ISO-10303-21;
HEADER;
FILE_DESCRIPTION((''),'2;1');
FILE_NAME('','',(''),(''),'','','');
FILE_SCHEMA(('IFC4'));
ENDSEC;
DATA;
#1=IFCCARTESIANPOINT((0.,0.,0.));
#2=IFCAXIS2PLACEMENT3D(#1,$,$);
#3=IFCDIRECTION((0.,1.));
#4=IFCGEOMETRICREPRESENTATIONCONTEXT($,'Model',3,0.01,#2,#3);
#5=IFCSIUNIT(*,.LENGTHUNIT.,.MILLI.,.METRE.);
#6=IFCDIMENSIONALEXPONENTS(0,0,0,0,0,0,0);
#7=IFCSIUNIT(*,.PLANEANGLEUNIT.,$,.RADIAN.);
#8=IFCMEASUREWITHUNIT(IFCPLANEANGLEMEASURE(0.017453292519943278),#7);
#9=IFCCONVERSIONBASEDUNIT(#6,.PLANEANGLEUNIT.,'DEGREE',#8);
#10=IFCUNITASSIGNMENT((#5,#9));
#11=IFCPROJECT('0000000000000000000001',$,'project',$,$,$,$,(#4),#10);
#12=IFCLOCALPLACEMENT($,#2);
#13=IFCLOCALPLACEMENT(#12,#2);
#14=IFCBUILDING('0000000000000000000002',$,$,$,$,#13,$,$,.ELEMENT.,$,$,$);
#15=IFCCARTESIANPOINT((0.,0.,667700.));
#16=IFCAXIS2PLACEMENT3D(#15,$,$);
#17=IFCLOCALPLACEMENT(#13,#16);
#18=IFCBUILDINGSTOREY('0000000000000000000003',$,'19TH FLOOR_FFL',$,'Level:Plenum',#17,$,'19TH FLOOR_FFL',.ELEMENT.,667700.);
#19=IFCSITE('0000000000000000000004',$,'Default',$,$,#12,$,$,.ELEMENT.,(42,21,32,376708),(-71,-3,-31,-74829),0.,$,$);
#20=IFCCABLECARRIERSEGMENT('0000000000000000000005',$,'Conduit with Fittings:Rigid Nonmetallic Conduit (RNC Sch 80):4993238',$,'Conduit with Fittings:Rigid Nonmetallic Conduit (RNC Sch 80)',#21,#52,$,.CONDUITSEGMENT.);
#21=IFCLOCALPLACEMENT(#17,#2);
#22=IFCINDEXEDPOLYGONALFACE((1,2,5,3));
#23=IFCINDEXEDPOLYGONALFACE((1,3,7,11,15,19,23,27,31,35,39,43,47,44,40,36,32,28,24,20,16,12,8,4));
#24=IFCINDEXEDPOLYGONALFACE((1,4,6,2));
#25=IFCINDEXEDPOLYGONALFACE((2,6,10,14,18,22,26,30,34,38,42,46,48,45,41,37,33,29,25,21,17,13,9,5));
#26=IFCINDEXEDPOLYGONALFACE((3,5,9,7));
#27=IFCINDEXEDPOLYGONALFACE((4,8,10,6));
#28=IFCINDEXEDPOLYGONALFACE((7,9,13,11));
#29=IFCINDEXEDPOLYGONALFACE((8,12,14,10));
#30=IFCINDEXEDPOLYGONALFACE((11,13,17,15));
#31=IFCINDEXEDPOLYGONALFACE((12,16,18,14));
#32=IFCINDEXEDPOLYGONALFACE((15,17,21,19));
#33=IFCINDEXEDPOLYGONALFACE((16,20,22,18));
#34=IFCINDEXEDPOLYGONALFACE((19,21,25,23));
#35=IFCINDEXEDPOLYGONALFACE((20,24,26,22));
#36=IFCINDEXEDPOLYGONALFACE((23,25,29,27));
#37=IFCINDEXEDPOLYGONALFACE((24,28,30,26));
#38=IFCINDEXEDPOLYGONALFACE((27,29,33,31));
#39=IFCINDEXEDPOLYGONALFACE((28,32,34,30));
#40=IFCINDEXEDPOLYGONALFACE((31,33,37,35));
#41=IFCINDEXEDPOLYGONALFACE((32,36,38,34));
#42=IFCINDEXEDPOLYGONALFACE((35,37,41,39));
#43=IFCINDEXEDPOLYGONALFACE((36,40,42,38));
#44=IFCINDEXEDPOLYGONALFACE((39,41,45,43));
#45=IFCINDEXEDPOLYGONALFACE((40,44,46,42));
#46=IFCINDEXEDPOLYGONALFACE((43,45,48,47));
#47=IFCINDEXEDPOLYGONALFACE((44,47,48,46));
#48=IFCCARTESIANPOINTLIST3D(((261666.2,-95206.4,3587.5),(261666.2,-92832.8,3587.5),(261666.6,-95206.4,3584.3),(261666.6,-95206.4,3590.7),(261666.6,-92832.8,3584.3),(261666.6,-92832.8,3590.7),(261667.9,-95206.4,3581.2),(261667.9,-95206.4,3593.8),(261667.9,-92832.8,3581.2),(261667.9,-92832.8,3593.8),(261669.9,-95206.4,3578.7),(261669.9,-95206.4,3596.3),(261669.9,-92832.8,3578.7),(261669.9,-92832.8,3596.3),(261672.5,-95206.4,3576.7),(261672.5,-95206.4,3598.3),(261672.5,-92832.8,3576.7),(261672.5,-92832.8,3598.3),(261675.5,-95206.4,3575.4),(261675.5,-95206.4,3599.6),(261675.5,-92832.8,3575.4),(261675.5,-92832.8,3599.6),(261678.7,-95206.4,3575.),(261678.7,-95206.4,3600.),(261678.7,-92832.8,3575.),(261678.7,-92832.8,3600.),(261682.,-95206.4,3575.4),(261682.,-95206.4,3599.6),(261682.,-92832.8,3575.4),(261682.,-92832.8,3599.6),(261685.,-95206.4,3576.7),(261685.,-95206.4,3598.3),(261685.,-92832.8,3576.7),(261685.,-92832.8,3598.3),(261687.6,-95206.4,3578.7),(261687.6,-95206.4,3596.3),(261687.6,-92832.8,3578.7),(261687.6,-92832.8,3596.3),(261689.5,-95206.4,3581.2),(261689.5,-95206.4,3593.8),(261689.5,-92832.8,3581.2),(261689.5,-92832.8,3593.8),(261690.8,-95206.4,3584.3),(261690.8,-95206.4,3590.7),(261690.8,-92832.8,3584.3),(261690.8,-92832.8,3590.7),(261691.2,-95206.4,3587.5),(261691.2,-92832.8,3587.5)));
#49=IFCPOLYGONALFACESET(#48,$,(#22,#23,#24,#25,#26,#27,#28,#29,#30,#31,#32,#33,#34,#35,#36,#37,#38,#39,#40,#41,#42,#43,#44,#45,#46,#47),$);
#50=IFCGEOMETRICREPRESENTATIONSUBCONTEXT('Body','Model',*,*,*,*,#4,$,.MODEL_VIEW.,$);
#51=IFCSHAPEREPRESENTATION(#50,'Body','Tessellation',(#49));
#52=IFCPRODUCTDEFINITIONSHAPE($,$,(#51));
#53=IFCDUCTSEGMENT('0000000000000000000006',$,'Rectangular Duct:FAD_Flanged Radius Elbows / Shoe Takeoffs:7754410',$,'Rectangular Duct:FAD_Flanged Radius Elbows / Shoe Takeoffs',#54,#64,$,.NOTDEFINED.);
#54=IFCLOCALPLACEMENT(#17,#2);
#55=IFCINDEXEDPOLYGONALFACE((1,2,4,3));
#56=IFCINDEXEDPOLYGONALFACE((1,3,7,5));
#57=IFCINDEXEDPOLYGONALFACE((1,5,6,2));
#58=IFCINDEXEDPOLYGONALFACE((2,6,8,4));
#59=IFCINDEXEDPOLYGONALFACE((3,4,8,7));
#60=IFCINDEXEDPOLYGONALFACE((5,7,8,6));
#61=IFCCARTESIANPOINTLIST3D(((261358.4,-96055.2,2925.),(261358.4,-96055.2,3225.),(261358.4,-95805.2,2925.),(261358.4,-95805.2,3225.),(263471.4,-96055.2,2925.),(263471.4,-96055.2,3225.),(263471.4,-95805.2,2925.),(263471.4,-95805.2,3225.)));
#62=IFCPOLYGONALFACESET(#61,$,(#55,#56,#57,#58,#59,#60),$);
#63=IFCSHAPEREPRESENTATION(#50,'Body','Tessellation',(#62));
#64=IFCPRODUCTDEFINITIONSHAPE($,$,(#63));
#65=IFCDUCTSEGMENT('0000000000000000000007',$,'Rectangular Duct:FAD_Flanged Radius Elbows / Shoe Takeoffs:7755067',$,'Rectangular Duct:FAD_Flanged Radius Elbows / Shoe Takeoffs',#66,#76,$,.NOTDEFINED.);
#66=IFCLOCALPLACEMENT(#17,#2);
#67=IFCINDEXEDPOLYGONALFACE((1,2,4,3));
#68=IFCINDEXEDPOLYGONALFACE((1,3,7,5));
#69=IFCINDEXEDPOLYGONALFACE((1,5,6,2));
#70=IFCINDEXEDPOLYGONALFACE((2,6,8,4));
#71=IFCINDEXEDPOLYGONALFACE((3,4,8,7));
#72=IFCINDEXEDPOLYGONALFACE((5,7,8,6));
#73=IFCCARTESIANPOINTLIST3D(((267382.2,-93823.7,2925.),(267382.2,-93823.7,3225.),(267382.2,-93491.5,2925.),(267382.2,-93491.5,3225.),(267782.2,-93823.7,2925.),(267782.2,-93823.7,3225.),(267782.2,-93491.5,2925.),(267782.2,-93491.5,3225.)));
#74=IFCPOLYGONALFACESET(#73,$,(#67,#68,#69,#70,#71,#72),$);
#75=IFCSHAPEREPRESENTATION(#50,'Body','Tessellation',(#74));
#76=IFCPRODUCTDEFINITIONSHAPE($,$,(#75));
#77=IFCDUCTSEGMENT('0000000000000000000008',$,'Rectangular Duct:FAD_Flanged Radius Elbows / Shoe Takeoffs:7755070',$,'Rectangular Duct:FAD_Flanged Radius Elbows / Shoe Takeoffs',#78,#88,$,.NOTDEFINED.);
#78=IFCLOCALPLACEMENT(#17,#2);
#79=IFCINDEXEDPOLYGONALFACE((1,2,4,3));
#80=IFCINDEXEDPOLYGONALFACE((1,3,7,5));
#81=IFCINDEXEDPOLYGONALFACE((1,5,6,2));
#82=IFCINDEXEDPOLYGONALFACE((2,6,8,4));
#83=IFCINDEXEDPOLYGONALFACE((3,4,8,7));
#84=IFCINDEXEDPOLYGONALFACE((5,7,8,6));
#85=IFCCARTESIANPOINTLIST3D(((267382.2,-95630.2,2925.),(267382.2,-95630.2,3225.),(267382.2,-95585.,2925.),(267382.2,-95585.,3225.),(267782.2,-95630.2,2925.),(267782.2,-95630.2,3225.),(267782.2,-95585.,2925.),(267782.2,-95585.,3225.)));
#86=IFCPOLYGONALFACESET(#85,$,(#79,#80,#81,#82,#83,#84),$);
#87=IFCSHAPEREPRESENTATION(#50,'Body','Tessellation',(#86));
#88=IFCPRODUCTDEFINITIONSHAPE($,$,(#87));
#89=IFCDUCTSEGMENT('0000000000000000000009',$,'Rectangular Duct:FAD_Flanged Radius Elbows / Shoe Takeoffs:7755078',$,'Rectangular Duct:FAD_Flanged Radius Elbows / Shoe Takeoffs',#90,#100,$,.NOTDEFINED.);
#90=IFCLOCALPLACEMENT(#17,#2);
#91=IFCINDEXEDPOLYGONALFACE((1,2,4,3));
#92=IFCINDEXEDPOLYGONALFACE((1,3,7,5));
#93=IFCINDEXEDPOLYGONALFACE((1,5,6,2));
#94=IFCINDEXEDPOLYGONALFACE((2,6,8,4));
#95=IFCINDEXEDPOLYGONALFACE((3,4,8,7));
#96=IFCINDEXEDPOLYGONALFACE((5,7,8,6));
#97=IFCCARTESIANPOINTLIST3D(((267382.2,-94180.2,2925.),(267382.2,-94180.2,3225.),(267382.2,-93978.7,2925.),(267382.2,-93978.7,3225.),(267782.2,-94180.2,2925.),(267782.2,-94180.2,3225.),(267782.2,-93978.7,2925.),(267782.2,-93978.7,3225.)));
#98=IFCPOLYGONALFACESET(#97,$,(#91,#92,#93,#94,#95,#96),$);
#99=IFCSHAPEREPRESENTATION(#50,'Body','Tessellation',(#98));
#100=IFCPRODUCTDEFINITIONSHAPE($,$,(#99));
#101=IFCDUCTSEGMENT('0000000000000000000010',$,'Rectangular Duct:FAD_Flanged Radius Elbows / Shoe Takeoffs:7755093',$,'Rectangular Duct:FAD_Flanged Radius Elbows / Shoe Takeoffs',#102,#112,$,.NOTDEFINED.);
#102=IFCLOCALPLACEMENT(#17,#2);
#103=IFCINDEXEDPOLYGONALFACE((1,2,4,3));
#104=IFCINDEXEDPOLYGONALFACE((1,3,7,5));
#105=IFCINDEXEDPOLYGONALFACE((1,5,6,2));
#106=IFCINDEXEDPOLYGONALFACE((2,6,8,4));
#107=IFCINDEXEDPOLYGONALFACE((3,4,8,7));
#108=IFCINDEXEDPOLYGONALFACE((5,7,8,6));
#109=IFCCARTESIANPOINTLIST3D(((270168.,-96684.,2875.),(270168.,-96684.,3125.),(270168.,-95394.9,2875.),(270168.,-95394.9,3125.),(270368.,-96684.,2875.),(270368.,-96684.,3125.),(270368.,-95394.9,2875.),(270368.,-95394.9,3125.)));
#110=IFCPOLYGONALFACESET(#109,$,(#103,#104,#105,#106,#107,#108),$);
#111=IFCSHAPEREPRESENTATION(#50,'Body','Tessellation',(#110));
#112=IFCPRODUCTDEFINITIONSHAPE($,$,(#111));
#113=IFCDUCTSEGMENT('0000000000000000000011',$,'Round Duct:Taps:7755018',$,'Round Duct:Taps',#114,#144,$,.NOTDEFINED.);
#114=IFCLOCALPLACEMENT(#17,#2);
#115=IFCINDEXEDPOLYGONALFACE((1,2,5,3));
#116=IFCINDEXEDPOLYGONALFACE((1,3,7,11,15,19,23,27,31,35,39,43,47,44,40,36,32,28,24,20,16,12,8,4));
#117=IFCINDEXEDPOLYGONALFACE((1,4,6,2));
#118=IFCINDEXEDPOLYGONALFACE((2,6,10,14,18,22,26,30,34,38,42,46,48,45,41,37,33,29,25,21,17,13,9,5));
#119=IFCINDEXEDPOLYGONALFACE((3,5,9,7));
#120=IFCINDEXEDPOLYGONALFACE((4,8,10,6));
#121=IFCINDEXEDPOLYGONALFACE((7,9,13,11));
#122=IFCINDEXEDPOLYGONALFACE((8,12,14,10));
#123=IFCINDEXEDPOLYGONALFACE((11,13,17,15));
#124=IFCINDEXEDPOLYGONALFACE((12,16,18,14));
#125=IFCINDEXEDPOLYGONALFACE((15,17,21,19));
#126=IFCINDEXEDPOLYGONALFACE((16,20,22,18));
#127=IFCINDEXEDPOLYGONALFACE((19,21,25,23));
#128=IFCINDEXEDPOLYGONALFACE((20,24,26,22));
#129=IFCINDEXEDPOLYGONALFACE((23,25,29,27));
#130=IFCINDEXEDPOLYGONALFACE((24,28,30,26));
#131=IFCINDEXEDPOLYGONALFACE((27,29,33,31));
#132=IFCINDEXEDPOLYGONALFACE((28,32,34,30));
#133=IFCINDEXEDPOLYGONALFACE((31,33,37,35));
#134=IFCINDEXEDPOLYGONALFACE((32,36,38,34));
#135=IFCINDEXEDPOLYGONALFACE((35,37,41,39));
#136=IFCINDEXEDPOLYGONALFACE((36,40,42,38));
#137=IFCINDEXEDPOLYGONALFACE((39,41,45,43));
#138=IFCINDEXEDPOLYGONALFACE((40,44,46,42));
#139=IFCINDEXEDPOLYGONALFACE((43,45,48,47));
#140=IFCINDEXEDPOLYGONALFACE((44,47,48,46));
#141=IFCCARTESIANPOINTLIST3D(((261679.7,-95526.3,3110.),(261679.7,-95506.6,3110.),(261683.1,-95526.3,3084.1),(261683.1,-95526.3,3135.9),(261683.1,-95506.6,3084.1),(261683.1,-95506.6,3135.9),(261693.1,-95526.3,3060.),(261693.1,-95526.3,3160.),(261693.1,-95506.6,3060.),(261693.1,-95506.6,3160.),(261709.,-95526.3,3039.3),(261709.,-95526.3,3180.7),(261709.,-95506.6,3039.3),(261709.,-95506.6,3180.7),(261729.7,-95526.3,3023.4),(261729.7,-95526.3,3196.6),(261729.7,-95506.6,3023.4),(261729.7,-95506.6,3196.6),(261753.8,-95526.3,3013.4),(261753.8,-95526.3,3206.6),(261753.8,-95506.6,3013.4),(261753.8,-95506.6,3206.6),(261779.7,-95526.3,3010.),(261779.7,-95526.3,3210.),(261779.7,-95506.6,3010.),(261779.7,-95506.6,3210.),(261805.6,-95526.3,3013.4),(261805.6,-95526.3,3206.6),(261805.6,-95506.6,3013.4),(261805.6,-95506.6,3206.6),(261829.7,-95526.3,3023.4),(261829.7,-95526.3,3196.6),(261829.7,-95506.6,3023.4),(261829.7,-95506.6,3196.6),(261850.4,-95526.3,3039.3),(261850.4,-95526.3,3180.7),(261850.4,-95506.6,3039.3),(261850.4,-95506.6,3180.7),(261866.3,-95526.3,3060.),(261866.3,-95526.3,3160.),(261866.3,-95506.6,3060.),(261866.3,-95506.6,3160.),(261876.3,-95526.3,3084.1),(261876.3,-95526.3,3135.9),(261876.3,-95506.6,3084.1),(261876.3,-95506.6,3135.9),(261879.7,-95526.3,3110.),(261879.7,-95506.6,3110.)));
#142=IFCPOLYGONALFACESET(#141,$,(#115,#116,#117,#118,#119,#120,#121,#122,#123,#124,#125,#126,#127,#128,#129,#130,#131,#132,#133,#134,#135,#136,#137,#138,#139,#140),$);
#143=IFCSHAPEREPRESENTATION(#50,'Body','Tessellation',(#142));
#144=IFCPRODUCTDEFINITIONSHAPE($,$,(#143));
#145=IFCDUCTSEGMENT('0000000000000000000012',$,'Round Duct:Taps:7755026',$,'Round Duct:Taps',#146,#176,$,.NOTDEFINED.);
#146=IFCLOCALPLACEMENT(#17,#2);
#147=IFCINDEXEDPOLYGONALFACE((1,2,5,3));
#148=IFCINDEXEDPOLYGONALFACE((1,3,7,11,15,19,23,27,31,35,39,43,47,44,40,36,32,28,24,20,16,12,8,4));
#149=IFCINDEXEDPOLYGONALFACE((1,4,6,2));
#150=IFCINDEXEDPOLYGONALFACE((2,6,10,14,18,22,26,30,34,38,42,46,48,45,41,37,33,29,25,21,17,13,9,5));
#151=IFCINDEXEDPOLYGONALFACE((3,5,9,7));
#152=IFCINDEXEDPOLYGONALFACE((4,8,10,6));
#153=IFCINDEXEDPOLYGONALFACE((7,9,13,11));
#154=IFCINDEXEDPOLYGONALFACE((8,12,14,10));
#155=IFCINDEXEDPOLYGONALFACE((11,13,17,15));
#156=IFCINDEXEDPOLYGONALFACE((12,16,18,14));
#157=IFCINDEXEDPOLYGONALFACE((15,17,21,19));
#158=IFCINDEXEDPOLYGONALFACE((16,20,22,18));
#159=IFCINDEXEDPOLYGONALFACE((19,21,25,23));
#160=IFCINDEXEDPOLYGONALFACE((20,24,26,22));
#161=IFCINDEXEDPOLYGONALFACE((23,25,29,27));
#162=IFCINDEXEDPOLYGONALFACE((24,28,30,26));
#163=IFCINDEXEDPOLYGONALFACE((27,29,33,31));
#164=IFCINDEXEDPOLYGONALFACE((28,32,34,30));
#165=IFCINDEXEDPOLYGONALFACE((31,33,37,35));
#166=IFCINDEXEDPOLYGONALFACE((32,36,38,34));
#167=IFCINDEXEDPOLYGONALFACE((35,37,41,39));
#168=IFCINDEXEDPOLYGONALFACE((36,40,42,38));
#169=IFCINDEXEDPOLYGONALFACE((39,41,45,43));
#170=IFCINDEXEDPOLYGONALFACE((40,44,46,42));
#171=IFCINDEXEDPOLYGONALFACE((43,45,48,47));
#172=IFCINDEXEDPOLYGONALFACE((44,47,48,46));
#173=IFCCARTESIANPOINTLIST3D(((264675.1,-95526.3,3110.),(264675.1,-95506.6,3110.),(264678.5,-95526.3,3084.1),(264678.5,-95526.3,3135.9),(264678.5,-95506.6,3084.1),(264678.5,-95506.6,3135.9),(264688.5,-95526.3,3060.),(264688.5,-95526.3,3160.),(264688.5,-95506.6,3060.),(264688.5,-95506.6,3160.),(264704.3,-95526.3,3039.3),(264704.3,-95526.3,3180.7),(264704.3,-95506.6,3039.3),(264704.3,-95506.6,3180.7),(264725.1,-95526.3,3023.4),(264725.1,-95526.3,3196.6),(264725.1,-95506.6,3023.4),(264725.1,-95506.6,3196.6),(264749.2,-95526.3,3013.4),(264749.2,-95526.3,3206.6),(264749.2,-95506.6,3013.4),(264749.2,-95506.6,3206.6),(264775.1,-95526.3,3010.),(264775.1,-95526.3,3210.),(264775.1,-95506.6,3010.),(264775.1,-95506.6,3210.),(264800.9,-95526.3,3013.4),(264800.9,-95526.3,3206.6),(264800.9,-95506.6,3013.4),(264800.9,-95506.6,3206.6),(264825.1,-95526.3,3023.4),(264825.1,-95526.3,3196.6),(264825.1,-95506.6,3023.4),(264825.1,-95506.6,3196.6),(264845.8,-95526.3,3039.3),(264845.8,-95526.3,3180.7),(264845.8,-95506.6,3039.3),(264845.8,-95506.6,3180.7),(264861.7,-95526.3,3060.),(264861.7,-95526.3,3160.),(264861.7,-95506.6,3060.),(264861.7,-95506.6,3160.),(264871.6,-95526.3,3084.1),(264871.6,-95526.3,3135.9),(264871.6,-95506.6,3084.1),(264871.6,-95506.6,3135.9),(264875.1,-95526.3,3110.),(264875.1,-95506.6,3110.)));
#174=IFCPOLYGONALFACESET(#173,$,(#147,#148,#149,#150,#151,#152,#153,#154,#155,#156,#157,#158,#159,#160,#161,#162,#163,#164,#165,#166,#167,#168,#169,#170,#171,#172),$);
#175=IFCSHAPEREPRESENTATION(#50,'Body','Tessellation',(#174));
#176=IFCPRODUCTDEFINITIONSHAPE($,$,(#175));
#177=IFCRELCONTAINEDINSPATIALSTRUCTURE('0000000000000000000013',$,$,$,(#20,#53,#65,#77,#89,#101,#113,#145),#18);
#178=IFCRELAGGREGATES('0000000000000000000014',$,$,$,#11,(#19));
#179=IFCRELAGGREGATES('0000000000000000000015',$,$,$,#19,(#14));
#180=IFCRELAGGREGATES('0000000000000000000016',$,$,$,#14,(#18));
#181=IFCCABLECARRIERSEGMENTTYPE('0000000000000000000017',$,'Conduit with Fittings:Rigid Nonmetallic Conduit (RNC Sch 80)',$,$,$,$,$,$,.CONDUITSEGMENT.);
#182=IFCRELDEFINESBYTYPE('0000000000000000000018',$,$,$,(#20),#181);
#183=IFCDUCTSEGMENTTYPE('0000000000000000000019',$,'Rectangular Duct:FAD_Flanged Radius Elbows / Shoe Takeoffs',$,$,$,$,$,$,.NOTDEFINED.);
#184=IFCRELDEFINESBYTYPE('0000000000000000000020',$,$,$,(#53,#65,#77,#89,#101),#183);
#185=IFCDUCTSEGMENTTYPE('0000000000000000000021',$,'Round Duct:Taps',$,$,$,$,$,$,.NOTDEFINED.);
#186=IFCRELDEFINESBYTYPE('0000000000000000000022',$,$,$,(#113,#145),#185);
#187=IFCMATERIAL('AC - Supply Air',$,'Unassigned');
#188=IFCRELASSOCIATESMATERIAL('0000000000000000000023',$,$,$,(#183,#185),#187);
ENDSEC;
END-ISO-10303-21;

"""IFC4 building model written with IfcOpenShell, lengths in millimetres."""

from ifc_helpers import new_model, entity, si_unit, converted_unit, direction, frame, origin, place, context, subcontext, project, spatial, arc, indexed_curve, outline, extrude, material, type_object, element, save


model = new_model("IFC4")

# Units and contexts
model_context = context("Model", 3, precision=0.01, world=origin(), true_north=direction((0.0, 1.0)))
body_context = subcontext(model_context, "Body", "Model", "MODEL_VIEW")
ifc_project = project(units=[si_unit("LENGTHUNIT", "METRE", prefix="MILLI"), converted_unit("PLANEANGLEUNIT", "DEGREE", entity("IfcPlaneAngleMeasure", 0.017453292519943278), si_unit("PLANEANGLEUNIT", "RADIAN"), dimensions=[0, 0, 0, 0, 0, 0, 0])], contexts=[model_context])

# Site, building, storey
site_placement = place(None, origin())
site = spatial("IfcSite", under=ifc_project, at=site_placement, Name="Default", CompositionType="ELEMENT", RefLatitude=(42, 21, 32, 376708), RefLongitude=(-71, -3, -31, -74829), RefElevation=0.0)
building_placement = place(site_placement, origin())
building = spatial("IfcBuilding", under=site, at=building_placement, CompositionType="ELEMENT")
storey_placement = place(building_placement, frame((0.0, 0.0, 667700.0)))
storey = spatial("IfcBuildingStorey", under=building, at=storey_placement, Name="19TH FLOOR_FFL", ObjectType="Level:Plenum", LongName="19TH FLOOR_FFL", CompositionType="ELEMENT", Elevation=667700.0)

# Cable carrier segment
cable_carrier_segment_type_1 = type_object("IfcCableCarrierSegmentType", Name="Conduit with Fittings:Rigid Nonmetallic Conduit (RNC Sch 80)", PredefinedType="CONDUITSEGMENT")
cable_carrier_segment_1_placement = place(storey_placement, origin())
element("IfcCableCarrierSegment", 1, at=cable_carrier_segment_1_placement, inside=storey, type_object=cable_carrier_segment_type_1, Name="Conduit with Fittings:Rigid Nonmetallic Conduit (RNC Sch 80):4993238", ObjectType="Conduit with Fittings:Rigid Nonmetallic Conduit (RNC Sch 80)", PredefinedType="CONDUITSEGMENT", context=body_context, shape_type="SweptSolid", body=[
    extrude(outline(indexed_curve([(12.5, 0.0), (8.8, 8.8), (0.0, 12.5), (-8.8, 8.8), (-12.5, 0.0), (-8.8, -8.8), (0.0, -12.5), (8.8, -8.8)], segments=[arc(1, 2, 3), arc(3, 4, 5), arc(5, 6, 7), arc(7, 8, 1)], self_intersect=False)), frame((261678.7, -95206.4, 3587.5), z_axis=(0.0, 1.0, 0.0), x_axis=(1.0, 0.0, 0.0)), (0.0, 0.0, 1.0), 2373.6),
])

# Duct segments
ifc_material_1 = material(Name="AC - Supply Air", Category="Unassigned")
duct_segment_type_1 = type_object("IfcDuctSegmentType", Name="Rectangular Duct:FAD_Flanged Radius Elbows / Shoe Takeoffs", PredefinedType="NOTDEFINED", material=ifc_material_1)
duct_segment_1_placement = place(storey_placement, origin())
element("IfcDuctSegment", 2, at=duct_segment_1_placement, inside=storey, type_object=duct_segment_type_1, Name="Rectangular Duct:FAD_Flanged Radius Elbows / Shoe Takeoffs:7754410", ObjectType="Rectangular Duct:FAD_Flanged Radius Elbows / Shoe Takeoffs", PredefinedType="NOTDEFINED", context=body_context, shape_type="SweptSolid", body=[
    extrude(outline(indexed_curve([(-1056.5, -125.0), (1056.5, -125.0), (1056.5, 125.0), (-1056.5, 125.0), (-1056.5, -125.0)], self_intersect=False)), frame((262414.9, -95930.2, 2925.0), z_axis=(0.0, 0.0, 1.0), x_axis=(-1.0, 0.0, 0.0)), (0.0, 0.0, 1.0), 300.0),
])
duct_segment_2_placement = place(storey_placement, origin())
element("IfcDuctSegment", 3, at=duct_segment_2_placement, inside=storey, type_object=duct_segment_type_1, Name="Rectangular Duct:FAD_Flanged Radius Elbows / Shoe Takeoffs:7755067", ObjectType="Rectangular Duct:FAD_Flanged Radius Elbows / Shoe Takeoffs", PredefinedType="NOTDEFINED", context=body_context, shape_type="SweptSolid", body=[
    extrude(outline(indexed_curve([(-166.1, -200.0), (166.1, -200.0), (166.1, 200.0), (-166.1, 200.0), (-166.1, -200.0)], self_intersect=False)), frame((267582.2, -93657.6, 2925.0), z_axis=(0.0, 0.0, 1.0), x_axis=(0.0, 1.0, 0.0)), (0.0, 0.0, 1.0), 300.0),
])
duct_segment_3_placement = place(storey_placement, origin())
element("IfcDuctSegment", 4, at=duct_segment_3_placement, inside=storey, type_object=duct_segment_type_1, Name="Rectangular Duct:FAD_Flanged Radius Elbows / Shoe Takeoffs:7755070", ObjectType="Rectangular Duct:FAD_Flanged Radius Elbows / Shoe Takeoffs", PredefinedType="NOTDEFINED", context=body_context, shape_type="SweptSolid", body=[
    extrude(outline(indexed_curve([(-22.6, -200.0), (22.6, -200.0), (22.6, 200.0), (-22.6, 200.0), (-22.6, -200.0)], self_intersect=False)), frame((267582.2, -95607.6, 2925.0), z_axis=(0.0, 0.0, 1.0), x_axis=(0.0, -1.0, 0.0)), (0.0, 0.0, 1.0), 300.0),
])
duct_segment_4_placement = place(storey_placement, origin())
element("IfcDuctSegment", 5, at=duct_segment_4_placement, inside=storey, type_object=duct_segment_type_1, Name="Rectangular Duct:FAD_Flanged Radius Elbows / Shoe Takeoffs:7755078", ObjectType="Rectangular Duct:FAD_Flanged Radius Elbows / Shoe Takeoffs", PredefinedType="NOTDEFINED", context=body_context, shape_type="SweptSolid", body=[
    extrude(outline(indexed_curve([(-100.7, -200.0), (100.7, -200.0), (100.7, 200.0), (-100.7, 200.0), (-100.7, -200.0)], self_intersect=False)), frame((267582.2, -94079.4, 2925.0), z_axis=(0.0, 0.0, 1.0), x_axis=(0.0, 1.0, 0.0)), (0.0, 0.0, 1.0), 300.0),
])
duct_segment_5_placement = place(storey_placement, origin())
element("IfcDuctSegment", 6, at=duct_segment_5_placement, inside=storey, type_object=duct_segment_type_1, Name="Rectangular Duct:FAD_Flanged Radius Elbows / Shoe Takeoffs:7755093", ObjectType="Rectangular Duct:FAD_Flanged Radius Elbows / Shoe Takeoffs", PredefinedType="NOTDEFINED", context=body_context, shape_type="SweptSolid", body=[
    extrude(outline(indexed_curve([(-644.5, -100.0), (644.5, -100.0), (644.5, 100.0), (-644.5, 100.0), (-644.5, -100.0)], self_intersect=False)), frame((270268.0, -96039.4, 2875.0), z_axis=(0.0, 0.0, 1.0), x_axis=(0.0, -1.0, 0.0)), (0.0, 0.0, 1.0), 250.0),
])
duct_segment_type_2 = type_object("IfcDuctSegmentType", Name="Round Duct:Taps", PredefinedType="NOTDEFINED", material=ifc_material_1)
duct_segment_6_placement = place(storey_placement, origin())
element("IfcDuctSegment", 7, at=duct_segment_6_placement, inside=storey, type_object=duct_segment_type_2, Name="Round Duct:Taps:7755018", ObjectType="Round Duct:Taps", PredefinedType="NOTDEFINED", context=body_context, shape_type="SweptSolid", body=[
    extrude(outline(indexed_curve([(100.0, 0.0), (70.7, 70.7), (0.0, 100.0), (-70.7, 70.7), (-100.0, 0.0), (-70.7, -70.7), (0.0, -100.0), (70.7, -70.7)], segments=[arc(1, 2, 3), arc(3, 4, 5), arc(5, 6, 7), arc(7, 8, 1)], self_intersect=False)), frame((261779.7, -95526.3, 3110.0), z_axis=(0.0, 1.0, 0.0), x_axis=(1.0, 0.0, 0.0)), (0.0, 0.0, 1.0), 19.6),
])
duct_segment_7_placement = place(storey_placement, origin())
element("IfcDuctSegment", 8, at=duct_segment_7_placement, inside=storey, type_object=duct_segment_type_2, Name="Round Duct:Taps:7755026", ObjectType="Round Duct:Taps", PredefinedType="NOTDEFINED", context=body_context, shape_type="SweptSolid", body=[
    extrude(outline(indexed_curve([(100.0, 0.0), (70.7, 70.7), (0.0, 100.0), (-70.7, 70.7), (-100.0, 0.0), (-70.7, -70.7), (0.0, -100.0), (70.7, -70.7)], segments=[arc(1, 2, 3), arc(3, 4, 5), arc(5, 6, 7), arc(7, 8, 1)], self_intersect=False)), frame((264775.1, -95526.3, 3110.0), z_axis=(0.0, 1.0, 0.0), x_axis=(1.0, 0.0, 0.0)), (0.0, 0.0, 1.0), 19.6),
])

save(model, "model.ifc")
